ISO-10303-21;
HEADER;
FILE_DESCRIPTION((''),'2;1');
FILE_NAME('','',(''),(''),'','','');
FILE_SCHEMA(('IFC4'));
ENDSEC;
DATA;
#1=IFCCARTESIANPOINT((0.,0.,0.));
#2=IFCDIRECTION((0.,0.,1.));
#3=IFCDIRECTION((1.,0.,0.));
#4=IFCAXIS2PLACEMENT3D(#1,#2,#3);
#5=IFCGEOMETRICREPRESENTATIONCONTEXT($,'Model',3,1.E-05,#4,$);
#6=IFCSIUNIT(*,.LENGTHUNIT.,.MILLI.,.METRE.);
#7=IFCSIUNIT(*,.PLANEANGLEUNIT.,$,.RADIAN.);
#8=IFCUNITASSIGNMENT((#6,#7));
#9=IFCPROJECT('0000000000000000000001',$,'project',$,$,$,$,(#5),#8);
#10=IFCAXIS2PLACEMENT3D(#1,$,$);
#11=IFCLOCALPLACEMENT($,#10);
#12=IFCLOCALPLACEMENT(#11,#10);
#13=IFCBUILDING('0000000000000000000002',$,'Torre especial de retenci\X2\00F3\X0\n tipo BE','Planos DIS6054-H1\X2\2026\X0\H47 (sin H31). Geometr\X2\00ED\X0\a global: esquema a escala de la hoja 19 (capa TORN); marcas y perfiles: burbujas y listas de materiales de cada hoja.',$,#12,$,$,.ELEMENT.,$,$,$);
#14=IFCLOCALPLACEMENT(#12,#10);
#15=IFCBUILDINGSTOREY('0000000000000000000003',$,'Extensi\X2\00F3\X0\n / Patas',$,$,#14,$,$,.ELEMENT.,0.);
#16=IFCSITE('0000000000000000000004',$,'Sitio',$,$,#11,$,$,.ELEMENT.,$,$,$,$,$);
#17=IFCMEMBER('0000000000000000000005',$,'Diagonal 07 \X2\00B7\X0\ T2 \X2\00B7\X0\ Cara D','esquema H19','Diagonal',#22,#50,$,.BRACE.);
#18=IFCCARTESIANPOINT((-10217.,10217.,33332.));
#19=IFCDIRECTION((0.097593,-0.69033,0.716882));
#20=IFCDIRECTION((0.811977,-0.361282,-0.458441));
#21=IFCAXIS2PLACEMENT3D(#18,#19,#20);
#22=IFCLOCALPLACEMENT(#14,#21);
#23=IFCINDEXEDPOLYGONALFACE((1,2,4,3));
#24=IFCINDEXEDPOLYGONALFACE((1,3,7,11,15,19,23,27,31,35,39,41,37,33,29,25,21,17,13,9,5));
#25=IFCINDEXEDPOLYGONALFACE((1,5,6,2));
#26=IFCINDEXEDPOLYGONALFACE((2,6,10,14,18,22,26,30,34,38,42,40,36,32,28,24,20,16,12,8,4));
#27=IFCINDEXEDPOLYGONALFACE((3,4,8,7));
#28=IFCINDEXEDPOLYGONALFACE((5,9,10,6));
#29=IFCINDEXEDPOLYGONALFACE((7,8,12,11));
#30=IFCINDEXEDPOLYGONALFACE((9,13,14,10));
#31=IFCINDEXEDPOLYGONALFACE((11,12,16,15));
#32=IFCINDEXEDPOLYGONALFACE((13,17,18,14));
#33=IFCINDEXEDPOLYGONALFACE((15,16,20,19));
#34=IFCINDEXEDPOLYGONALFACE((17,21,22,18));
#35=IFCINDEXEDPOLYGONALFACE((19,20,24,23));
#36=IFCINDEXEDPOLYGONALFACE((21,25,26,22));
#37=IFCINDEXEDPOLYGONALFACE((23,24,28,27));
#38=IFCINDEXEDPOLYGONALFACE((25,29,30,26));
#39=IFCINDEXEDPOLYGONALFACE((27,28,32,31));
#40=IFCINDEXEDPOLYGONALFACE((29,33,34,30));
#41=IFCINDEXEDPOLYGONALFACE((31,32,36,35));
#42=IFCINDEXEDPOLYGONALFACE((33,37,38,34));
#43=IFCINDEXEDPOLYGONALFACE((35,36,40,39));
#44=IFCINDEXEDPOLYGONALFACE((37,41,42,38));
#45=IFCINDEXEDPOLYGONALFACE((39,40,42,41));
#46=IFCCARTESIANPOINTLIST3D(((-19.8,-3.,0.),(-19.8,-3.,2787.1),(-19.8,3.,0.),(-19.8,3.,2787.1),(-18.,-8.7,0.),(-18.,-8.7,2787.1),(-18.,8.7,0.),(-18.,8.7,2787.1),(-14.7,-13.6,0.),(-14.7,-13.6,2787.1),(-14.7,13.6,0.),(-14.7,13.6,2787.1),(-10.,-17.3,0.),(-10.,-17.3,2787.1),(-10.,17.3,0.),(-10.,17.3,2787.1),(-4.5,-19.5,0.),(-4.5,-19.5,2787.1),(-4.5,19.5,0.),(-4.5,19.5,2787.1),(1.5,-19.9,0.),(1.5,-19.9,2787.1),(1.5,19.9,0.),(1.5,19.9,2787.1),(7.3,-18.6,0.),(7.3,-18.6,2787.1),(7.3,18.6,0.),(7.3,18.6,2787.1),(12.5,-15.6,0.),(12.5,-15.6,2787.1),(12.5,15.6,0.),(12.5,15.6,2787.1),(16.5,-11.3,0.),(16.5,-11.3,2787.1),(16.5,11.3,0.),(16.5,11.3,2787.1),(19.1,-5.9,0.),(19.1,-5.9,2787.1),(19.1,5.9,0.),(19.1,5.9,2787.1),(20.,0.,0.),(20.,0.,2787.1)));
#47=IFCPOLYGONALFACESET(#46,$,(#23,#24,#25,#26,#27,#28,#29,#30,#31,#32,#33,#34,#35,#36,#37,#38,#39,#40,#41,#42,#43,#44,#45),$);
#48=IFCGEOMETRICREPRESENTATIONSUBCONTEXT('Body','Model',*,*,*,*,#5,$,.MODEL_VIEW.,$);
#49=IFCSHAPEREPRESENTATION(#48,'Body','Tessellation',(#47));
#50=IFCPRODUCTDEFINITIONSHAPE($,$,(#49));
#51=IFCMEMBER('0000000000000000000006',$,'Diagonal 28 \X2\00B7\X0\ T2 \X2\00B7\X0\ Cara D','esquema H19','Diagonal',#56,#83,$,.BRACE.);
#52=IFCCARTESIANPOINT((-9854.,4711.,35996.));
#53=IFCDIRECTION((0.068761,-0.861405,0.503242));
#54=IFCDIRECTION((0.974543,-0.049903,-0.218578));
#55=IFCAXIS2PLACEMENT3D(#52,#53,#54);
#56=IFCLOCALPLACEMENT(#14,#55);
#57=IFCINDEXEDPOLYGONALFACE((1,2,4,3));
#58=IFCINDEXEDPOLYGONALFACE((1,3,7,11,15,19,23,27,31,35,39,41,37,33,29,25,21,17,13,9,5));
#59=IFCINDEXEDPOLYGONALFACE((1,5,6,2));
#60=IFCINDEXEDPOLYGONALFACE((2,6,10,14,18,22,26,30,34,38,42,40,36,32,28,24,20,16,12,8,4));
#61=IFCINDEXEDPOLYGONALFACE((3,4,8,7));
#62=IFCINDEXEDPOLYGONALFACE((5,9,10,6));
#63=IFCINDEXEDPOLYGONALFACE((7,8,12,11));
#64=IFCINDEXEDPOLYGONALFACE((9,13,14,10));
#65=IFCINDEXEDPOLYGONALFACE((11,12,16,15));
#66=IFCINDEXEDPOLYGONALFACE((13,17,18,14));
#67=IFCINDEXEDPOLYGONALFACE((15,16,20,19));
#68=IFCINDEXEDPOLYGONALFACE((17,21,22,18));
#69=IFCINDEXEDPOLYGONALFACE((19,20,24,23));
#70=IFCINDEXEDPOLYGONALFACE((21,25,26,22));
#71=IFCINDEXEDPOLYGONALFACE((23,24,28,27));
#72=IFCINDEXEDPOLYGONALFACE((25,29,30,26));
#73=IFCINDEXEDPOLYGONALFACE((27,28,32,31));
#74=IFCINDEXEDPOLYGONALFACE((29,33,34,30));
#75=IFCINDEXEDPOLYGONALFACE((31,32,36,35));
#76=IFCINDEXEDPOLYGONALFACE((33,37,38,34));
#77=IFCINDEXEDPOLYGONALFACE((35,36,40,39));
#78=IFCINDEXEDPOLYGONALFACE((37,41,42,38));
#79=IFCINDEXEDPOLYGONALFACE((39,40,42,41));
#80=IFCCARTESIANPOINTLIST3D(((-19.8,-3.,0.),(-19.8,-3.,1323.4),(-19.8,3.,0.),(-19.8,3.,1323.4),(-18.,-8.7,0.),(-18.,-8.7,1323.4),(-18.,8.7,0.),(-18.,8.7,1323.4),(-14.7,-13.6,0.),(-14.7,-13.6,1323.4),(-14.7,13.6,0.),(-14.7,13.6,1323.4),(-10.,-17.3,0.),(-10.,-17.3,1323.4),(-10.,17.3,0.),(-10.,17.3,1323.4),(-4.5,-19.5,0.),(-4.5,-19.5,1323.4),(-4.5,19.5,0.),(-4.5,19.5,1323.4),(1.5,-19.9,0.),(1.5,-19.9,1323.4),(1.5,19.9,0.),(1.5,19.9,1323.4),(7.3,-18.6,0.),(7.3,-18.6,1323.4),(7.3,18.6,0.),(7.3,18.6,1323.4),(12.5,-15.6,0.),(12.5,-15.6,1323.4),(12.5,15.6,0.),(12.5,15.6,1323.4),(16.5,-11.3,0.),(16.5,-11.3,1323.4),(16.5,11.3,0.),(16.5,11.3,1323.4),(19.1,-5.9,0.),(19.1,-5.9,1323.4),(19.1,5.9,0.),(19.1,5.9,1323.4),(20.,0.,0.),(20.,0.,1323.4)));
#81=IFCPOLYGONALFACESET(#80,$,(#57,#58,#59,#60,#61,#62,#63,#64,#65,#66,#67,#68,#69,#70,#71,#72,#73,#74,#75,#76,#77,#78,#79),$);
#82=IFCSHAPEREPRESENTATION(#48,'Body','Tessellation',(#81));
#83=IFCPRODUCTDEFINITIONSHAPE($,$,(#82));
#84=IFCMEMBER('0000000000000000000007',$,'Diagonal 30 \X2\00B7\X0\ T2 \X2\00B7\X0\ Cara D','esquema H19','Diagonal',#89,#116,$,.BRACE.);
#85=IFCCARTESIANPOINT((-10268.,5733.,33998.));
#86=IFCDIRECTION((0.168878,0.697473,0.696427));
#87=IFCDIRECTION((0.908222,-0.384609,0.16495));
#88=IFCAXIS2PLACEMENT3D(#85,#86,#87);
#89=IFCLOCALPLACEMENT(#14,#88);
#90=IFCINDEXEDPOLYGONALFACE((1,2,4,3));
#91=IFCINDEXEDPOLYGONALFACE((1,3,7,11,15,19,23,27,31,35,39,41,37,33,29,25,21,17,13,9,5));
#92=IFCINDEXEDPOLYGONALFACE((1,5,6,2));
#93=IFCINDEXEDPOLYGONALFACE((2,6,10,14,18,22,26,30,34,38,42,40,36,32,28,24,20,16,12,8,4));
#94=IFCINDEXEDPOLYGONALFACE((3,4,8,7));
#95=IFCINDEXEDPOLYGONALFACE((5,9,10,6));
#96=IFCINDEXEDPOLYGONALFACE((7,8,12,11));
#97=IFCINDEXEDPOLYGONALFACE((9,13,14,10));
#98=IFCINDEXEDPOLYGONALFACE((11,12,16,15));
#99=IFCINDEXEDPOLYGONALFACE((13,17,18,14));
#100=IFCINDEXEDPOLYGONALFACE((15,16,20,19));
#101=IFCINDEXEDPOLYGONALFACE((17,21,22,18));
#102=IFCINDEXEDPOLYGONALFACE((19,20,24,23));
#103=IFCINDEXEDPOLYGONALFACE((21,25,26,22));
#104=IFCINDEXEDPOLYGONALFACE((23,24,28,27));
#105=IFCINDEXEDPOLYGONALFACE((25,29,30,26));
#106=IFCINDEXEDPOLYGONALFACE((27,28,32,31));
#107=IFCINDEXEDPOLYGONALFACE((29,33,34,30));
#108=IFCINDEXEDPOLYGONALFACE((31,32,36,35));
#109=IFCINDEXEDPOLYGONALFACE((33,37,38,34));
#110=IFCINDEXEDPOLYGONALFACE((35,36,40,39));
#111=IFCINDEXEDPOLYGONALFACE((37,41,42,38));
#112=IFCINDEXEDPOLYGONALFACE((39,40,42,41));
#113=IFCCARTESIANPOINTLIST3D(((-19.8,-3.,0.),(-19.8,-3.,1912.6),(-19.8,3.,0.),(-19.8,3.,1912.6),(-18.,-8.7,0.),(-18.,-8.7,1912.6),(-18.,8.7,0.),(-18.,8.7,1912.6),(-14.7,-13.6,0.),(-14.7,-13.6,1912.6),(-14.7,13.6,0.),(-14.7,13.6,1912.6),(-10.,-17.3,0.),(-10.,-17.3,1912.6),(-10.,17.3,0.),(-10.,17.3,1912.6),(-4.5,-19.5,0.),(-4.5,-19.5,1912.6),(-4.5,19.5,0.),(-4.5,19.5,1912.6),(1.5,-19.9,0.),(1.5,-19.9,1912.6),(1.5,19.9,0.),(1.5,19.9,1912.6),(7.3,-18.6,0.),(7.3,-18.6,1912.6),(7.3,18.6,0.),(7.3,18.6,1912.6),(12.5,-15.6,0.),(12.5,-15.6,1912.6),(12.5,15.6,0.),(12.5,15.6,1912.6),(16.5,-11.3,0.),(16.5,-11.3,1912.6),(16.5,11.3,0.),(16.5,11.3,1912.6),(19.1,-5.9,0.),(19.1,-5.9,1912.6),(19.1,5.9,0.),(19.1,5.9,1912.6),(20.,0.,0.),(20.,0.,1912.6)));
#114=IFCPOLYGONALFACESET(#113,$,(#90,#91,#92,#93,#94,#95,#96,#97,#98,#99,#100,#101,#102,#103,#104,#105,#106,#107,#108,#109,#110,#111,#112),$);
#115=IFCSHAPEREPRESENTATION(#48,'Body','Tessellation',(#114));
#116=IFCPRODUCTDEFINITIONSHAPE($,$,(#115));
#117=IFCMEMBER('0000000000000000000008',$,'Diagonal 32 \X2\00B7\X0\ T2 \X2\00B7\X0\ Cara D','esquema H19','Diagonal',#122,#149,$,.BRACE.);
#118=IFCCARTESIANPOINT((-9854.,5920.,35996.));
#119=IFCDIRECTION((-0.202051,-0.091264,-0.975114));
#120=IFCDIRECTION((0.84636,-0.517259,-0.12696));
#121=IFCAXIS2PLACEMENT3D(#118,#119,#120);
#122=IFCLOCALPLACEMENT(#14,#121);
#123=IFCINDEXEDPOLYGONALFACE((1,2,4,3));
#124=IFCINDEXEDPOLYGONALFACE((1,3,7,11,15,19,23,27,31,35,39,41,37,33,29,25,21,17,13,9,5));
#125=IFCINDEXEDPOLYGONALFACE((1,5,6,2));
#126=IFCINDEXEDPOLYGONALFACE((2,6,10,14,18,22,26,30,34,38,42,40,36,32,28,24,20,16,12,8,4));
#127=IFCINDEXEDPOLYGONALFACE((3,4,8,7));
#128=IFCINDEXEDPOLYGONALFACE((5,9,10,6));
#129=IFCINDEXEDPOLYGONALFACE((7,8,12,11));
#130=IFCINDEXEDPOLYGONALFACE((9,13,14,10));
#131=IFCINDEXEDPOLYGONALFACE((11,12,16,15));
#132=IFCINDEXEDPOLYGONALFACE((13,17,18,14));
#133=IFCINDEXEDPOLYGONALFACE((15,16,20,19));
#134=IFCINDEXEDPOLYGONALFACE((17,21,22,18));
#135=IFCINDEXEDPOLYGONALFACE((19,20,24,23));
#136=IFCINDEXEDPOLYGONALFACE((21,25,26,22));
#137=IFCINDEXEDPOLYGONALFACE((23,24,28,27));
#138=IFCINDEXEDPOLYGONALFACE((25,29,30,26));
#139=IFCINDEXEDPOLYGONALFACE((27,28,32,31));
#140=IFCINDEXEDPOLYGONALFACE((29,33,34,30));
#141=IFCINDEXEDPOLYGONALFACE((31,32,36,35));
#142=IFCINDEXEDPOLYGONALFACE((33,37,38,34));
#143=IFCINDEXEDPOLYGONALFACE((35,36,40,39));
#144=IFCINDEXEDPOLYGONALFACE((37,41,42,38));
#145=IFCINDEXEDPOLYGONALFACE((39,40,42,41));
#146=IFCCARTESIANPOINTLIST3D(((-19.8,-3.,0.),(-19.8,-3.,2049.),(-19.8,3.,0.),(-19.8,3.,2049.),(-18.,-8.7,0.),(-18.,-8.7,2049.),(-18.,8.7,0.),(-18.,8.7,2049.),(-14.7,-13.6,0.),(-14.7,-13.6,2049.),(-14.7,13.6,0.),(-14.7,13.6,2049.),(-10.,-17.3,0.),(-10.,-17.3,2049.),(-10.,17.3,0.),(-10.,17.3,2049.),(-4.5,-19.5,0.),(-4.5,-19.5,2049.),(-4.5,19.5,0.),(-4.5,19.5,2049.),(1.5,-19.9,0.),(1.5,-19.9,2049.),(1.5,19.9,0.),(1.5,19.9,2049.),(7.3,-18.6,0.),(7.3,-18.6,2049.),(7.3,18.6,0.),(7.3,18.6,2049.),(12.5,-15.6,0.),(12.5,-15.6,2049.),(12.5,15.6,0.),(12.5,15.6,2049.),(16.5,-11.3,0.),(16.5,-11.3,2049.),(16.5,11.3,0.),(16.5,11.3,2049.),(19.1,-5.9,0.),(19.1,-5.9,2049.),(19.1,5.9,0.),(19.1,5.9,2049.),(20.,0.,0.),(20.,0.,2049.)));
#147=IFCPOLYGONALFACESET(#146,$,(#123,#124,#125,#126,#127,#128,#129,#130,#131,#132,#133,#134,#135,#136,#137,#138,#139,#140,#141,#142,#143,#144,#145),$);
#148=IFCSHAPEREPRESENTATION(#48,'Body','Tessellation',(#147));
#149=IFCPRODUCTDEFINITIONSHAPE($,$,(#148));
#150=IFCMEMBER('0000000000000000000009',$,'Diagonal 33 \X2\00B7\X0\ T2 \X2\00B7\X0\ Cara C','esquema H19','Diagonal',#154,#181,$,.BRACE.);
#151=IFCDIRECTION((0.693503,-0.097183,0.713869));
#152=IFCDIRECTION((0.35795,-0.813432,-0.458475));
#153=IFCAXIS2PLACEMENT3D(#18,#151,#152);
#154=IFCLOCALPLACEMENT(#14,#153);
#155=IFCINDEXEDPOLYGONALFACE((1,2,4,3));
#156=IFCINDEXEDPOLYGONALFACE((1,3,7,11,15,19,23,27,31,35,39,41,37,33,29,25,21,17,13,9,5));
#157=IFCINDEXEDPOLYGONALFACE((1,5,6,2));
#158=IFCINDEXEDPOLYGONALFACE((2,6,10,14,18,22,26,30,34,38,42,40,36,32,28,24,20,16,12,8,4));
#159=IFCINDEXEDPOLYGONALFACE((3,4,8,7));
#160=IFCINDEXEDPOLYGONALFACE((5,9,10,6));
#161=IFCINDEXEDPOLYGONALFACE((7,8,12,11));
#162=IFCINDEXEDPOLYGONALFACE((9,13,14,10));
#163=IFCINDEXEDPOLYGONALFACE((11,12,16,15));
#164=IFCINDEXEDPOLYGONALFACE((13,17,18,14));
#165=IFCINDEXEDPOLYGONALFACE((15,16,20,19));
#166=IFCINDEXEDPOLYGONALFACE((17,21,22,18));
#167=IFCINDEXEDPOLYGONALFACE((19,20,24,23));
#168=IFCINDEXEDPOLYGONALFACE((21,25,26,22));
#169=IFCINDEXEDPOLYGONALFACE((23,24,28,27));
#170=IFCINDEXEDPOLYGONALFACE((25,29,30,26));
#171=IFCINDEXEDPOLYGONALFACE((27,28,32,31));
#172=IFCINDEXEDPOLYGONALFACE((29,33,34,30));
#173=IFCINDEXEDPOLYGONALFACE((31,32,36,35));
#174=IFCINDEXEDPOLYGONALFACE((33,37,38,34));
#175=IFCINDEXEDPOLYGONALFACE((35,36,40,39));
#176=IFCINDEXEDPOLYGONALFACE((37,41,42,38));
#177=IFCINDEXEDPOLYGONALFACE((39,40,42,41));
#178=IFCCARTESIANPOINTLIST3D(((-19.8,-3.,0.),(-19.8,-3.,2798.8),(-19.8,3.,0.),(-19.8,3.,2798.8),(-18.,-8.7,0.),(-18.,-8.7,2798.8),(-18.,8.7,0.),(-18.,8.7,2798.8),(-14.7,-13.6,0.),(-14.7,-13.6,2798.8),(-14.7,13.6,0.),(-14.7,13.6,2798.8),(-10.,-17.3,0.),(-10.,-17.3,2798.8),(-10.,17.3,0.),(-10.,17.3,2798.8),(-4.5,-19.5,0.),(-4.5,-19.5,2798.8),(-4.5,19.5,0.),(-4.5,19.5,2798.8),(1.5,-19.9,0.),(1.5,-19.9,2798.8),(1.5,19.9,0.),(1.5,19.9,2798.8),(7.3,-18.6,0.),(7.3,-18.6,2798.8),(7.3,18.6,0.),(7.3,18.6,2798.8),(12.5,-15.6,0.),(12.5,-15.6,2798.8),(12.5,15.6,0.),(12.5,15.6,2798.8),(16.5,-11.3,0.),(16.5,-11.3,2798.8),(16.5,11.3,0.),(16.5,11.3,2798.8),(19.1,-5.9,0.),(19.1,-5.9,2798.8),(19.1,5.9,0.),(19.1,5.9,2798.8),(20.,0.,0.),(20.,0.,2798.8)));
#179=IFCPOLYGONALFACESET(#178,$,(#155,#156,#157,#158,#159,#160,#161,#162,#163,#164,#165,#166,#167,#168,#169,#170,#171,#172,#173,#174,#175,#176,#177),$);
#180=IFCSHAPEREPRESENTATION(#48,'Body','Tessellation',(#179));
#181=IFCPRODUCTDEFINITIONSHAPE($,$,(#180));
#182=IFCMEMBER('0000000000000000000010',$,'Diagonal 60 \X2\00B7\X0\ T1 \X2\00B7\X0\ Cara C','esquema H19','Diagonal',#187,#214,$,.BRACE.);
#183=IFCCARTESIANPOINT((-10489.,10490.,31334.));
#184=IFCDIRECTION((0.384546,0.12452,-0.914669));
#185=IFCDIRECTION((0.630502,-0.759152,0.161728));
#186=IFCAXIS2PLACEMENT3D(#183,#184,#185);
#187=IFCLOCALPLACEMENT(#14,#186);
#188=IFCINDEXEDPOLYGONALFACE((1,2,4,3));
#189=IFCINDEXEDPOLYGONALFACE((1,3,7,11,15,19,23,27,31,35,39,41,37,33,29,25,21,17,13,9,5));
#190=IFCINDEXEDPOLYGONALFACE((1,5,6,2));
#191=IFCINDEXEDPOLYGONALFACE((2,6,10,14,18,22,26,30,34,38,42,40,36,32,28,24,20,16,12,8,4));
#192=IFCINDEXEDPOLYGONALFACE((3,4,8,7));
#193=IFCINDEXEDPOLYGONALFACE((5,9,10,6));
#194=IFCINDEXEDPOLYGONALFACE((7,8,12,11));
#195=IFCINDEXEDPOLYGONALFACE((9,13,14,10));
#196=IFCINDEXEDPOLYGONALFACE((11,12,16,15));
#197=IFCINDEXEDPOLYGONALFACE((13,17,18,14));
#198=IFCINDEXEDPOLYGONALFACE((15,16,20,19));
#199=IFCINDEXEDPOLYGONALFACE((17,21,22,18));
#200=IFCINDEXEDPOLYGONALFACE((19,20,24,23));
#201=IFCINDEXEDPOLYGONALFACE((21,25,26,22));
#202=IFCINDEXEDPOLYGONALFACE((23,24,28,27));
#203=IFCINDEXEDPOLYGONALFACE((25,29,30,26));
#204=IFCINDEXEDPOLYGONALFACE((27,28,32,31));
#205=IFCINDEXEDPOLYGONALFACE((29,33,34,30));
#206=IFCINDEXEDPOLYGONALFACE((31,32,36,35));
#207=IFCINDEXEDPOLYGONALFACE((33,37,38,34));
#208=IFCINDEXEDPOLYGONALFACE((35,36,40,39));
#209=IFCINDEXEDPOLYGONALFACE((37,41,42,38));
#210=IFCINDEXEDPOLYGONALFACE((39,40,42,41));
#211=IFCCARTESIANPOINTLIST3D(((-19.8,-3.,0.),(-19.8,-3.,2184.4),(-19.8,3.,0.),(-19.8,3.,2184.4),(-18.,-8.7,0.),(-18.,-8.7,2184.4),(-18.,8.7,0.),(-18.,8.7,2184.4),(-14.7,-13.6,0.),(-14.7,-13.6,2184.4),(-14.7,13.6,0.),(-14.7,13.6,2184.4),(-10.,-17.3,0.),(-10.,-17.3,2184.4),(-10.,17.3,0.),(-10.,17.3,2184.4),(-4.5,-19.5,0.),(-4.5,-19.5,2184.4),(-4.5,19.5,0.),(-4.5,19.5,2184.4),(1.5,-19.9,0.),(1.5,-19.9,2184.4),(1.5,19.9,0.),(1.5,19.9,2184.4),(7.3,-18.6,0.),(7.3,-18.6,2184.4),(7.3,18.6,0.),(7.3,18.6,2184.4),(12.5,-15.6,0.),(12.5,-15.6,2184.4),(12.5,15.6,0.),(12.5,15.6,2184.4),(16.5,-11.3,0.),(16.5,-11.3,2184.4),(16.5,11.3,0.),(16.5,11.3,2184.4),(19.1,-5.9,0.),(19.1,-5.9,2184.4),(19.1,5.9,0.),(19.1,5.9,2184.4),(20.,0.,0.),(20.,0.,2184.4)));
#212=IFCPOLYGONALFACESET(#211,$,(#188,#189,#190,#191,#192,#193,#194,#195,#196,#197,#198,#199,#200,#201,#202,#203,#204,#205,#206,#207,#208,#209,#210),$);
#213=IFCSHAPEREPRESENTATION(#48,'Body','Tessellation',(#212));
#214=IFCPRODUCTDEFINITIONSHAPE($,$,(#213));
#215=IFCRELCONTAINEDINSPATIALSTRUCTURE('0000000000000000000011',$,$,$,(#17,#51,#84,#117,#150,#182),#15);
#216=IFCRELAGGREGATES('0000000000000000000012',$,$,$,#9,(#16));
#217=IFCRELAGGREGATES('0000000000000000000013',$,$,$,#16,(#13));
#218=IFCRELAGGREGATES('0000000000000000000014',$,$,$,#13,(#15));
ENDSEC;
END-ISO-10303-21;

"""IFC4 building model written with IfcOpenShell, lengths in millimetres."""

from ifc_helpers import new_model, si_unit, frame, origin, origin_with_axes, place, context, subcontext, project, spatial, circle, extrude, element, save


model = new_model("IFC4")

# Units and contexts
model_context = context("Model", 3, precision=1e-05, world=origin_with_axes())
body_context = subcontext(model_context, "Body", "Model", "MODEL_VIEW")
ifc_project = project(units=[si_unit("LENGTHUNIT", "METRE", prefix="MILLI"), si_unit("PLANEANGLEUNIT", "RADIAN")], contexts=[model_context])

# Site, building, storey
site_placement = place(None, origin())
site = spatial("IfcSite", under=ifc_project, at=site_placement, Name="Sitio", CompositionType="ELEMENT")
building_placement = place(site_placement, origin())
building = spatial("IfcBuilding", under=site, at=building_placement, Name="Torre especial de retención tipo BE", Description="Planos DIS6054-H1…H47 (sin H31). Geometría global: esquema a escala de la hoja 19 (capa TORN); marcas y perfiles: burbujas y listas de materiales de cada hoja.", CompositionType="ELEMENT")
storey_placement = place(building_placement, origin())
storey = spatial("IfcBuildingStorey", under=building, at=storey_placement, Name="Extensión / Patas", CompositionType="ELEMENT", Elevation=0.0)

# Members
member_1_placement = place(storey_placement, frame((-10217.0, 10217.0, 33332.0), z_axis=(0.097593, -0.69033, 0.716882), x_axis=(0.811977, -0.361282, -0.458441)))
element("IfcMember", 1, at=member_1_placement, inside=storey, Name="Diagonal 07 · T2 · Cara D", Description="esquema H19", ObjectType="Diagonal", PredefinedType="BRACE", context=body_context, shape_type="SweptSolid", body=[
    extrude(circle(Radius=20.0), None, (0.0, 0.0, 1.0), 2787.1),
])
member_2_placement = place(storey_placement, frame((-9854.0, 4711.0, 35996.0), z_axis=(0.068761, -0.861405, 0.503242), x_axis=(0.974543, -0.049903, -0.218578)))
element("IfcMember", 2, at=member_2_placement, inside=storey, Name="Diagonal 28 · T2 · Cara D", Description="esquema H19", ObjectType="Diagonal", PredefinedType="BRACE", context=body_context, shape_type="SweptSolid", body=[
    extrude(circle(Radius=20.0), None, (0.0, 0.0, 1.0), 1323.4),
])
member_3_placement = place(storey_placement, frame((-10268.0, 5733.0, 33998.0), z_axis=(0.168878, 0.697473, 0.696427), x_axis=(0.908222, -0.384609, 0.16495)))
element("IfcMember", 3, at=member_3_placement, inside=storey, Name="Diagonal 30 · T2 · Cara D", Description="esquema H19", ObjectType="Diagonal", PredefinedType="BRACE", context=body_context, shape_type="SweptSolid", body=[
    extrude(circle(Radius=20.0), None, (0.0, 0.0, 1.0), 1912.6),
])
member_4_placement = place(storey_placement, frame((-9854.0, 5920.0, 35996.0), z_axis=(-0.202051, -0.091264, -0.975114), x_axis=(0.84636, -0.517259, -0.12696)))
element("IfcMember", 4, at=member_4_placement, inside=storey, Name="Diagonal 32 · T2 · Cara D", Description="esquema H19", ObjectType="Diagonal", PredefinedType="BRACE", context=body_context, shape_type="SweptSolid", body=[
    extrude(circle(Radius=20.0), None, (0.0, 0.0, 1.0), 2049.0),
])
member_5_placement = place(storey_placement, frame((-10217.0, 10217.0, 33332.0), z_axis=(0.693503, -0.097183, 0.713869), x_axis=(0.35795, -0.813432, -0.458475)))
element("IfcMember", 5, at=member_5_placement, inside=storey, Name="Diagonal 33 · T2 · Cara C", Description="esquema H19", ObjectType="Diagonal", PredefinedType="BRACE", context=body_context, shape_type="SweptSolid", body=[
    extrude(circle(Radius=20.0), None, (0.0, 0.0, 1.0), 2798.8),
])
member_6_placement = place(storey_placement, frame((-10489.0, 10490.0, 31334.0), z_axis=(0.384546, 0.12452, -0.914669), x_axis=(0.630502, -0.759152, 0.161728)))
element("IfcMember", 6, at=member_6_placement, inside=storey, Name="Diagonal 60 · T1 · Cara C", Description="esquema H19", ObjectType="Diagonal", PredefinedType="BRACE", context=body_context, shape_type="SweptSolid", body=[
    extrude(circle(Radius=20.0), None, (0.0, 0.0, 1.0), 2184.4),
])

save(model, "model.ifc")
